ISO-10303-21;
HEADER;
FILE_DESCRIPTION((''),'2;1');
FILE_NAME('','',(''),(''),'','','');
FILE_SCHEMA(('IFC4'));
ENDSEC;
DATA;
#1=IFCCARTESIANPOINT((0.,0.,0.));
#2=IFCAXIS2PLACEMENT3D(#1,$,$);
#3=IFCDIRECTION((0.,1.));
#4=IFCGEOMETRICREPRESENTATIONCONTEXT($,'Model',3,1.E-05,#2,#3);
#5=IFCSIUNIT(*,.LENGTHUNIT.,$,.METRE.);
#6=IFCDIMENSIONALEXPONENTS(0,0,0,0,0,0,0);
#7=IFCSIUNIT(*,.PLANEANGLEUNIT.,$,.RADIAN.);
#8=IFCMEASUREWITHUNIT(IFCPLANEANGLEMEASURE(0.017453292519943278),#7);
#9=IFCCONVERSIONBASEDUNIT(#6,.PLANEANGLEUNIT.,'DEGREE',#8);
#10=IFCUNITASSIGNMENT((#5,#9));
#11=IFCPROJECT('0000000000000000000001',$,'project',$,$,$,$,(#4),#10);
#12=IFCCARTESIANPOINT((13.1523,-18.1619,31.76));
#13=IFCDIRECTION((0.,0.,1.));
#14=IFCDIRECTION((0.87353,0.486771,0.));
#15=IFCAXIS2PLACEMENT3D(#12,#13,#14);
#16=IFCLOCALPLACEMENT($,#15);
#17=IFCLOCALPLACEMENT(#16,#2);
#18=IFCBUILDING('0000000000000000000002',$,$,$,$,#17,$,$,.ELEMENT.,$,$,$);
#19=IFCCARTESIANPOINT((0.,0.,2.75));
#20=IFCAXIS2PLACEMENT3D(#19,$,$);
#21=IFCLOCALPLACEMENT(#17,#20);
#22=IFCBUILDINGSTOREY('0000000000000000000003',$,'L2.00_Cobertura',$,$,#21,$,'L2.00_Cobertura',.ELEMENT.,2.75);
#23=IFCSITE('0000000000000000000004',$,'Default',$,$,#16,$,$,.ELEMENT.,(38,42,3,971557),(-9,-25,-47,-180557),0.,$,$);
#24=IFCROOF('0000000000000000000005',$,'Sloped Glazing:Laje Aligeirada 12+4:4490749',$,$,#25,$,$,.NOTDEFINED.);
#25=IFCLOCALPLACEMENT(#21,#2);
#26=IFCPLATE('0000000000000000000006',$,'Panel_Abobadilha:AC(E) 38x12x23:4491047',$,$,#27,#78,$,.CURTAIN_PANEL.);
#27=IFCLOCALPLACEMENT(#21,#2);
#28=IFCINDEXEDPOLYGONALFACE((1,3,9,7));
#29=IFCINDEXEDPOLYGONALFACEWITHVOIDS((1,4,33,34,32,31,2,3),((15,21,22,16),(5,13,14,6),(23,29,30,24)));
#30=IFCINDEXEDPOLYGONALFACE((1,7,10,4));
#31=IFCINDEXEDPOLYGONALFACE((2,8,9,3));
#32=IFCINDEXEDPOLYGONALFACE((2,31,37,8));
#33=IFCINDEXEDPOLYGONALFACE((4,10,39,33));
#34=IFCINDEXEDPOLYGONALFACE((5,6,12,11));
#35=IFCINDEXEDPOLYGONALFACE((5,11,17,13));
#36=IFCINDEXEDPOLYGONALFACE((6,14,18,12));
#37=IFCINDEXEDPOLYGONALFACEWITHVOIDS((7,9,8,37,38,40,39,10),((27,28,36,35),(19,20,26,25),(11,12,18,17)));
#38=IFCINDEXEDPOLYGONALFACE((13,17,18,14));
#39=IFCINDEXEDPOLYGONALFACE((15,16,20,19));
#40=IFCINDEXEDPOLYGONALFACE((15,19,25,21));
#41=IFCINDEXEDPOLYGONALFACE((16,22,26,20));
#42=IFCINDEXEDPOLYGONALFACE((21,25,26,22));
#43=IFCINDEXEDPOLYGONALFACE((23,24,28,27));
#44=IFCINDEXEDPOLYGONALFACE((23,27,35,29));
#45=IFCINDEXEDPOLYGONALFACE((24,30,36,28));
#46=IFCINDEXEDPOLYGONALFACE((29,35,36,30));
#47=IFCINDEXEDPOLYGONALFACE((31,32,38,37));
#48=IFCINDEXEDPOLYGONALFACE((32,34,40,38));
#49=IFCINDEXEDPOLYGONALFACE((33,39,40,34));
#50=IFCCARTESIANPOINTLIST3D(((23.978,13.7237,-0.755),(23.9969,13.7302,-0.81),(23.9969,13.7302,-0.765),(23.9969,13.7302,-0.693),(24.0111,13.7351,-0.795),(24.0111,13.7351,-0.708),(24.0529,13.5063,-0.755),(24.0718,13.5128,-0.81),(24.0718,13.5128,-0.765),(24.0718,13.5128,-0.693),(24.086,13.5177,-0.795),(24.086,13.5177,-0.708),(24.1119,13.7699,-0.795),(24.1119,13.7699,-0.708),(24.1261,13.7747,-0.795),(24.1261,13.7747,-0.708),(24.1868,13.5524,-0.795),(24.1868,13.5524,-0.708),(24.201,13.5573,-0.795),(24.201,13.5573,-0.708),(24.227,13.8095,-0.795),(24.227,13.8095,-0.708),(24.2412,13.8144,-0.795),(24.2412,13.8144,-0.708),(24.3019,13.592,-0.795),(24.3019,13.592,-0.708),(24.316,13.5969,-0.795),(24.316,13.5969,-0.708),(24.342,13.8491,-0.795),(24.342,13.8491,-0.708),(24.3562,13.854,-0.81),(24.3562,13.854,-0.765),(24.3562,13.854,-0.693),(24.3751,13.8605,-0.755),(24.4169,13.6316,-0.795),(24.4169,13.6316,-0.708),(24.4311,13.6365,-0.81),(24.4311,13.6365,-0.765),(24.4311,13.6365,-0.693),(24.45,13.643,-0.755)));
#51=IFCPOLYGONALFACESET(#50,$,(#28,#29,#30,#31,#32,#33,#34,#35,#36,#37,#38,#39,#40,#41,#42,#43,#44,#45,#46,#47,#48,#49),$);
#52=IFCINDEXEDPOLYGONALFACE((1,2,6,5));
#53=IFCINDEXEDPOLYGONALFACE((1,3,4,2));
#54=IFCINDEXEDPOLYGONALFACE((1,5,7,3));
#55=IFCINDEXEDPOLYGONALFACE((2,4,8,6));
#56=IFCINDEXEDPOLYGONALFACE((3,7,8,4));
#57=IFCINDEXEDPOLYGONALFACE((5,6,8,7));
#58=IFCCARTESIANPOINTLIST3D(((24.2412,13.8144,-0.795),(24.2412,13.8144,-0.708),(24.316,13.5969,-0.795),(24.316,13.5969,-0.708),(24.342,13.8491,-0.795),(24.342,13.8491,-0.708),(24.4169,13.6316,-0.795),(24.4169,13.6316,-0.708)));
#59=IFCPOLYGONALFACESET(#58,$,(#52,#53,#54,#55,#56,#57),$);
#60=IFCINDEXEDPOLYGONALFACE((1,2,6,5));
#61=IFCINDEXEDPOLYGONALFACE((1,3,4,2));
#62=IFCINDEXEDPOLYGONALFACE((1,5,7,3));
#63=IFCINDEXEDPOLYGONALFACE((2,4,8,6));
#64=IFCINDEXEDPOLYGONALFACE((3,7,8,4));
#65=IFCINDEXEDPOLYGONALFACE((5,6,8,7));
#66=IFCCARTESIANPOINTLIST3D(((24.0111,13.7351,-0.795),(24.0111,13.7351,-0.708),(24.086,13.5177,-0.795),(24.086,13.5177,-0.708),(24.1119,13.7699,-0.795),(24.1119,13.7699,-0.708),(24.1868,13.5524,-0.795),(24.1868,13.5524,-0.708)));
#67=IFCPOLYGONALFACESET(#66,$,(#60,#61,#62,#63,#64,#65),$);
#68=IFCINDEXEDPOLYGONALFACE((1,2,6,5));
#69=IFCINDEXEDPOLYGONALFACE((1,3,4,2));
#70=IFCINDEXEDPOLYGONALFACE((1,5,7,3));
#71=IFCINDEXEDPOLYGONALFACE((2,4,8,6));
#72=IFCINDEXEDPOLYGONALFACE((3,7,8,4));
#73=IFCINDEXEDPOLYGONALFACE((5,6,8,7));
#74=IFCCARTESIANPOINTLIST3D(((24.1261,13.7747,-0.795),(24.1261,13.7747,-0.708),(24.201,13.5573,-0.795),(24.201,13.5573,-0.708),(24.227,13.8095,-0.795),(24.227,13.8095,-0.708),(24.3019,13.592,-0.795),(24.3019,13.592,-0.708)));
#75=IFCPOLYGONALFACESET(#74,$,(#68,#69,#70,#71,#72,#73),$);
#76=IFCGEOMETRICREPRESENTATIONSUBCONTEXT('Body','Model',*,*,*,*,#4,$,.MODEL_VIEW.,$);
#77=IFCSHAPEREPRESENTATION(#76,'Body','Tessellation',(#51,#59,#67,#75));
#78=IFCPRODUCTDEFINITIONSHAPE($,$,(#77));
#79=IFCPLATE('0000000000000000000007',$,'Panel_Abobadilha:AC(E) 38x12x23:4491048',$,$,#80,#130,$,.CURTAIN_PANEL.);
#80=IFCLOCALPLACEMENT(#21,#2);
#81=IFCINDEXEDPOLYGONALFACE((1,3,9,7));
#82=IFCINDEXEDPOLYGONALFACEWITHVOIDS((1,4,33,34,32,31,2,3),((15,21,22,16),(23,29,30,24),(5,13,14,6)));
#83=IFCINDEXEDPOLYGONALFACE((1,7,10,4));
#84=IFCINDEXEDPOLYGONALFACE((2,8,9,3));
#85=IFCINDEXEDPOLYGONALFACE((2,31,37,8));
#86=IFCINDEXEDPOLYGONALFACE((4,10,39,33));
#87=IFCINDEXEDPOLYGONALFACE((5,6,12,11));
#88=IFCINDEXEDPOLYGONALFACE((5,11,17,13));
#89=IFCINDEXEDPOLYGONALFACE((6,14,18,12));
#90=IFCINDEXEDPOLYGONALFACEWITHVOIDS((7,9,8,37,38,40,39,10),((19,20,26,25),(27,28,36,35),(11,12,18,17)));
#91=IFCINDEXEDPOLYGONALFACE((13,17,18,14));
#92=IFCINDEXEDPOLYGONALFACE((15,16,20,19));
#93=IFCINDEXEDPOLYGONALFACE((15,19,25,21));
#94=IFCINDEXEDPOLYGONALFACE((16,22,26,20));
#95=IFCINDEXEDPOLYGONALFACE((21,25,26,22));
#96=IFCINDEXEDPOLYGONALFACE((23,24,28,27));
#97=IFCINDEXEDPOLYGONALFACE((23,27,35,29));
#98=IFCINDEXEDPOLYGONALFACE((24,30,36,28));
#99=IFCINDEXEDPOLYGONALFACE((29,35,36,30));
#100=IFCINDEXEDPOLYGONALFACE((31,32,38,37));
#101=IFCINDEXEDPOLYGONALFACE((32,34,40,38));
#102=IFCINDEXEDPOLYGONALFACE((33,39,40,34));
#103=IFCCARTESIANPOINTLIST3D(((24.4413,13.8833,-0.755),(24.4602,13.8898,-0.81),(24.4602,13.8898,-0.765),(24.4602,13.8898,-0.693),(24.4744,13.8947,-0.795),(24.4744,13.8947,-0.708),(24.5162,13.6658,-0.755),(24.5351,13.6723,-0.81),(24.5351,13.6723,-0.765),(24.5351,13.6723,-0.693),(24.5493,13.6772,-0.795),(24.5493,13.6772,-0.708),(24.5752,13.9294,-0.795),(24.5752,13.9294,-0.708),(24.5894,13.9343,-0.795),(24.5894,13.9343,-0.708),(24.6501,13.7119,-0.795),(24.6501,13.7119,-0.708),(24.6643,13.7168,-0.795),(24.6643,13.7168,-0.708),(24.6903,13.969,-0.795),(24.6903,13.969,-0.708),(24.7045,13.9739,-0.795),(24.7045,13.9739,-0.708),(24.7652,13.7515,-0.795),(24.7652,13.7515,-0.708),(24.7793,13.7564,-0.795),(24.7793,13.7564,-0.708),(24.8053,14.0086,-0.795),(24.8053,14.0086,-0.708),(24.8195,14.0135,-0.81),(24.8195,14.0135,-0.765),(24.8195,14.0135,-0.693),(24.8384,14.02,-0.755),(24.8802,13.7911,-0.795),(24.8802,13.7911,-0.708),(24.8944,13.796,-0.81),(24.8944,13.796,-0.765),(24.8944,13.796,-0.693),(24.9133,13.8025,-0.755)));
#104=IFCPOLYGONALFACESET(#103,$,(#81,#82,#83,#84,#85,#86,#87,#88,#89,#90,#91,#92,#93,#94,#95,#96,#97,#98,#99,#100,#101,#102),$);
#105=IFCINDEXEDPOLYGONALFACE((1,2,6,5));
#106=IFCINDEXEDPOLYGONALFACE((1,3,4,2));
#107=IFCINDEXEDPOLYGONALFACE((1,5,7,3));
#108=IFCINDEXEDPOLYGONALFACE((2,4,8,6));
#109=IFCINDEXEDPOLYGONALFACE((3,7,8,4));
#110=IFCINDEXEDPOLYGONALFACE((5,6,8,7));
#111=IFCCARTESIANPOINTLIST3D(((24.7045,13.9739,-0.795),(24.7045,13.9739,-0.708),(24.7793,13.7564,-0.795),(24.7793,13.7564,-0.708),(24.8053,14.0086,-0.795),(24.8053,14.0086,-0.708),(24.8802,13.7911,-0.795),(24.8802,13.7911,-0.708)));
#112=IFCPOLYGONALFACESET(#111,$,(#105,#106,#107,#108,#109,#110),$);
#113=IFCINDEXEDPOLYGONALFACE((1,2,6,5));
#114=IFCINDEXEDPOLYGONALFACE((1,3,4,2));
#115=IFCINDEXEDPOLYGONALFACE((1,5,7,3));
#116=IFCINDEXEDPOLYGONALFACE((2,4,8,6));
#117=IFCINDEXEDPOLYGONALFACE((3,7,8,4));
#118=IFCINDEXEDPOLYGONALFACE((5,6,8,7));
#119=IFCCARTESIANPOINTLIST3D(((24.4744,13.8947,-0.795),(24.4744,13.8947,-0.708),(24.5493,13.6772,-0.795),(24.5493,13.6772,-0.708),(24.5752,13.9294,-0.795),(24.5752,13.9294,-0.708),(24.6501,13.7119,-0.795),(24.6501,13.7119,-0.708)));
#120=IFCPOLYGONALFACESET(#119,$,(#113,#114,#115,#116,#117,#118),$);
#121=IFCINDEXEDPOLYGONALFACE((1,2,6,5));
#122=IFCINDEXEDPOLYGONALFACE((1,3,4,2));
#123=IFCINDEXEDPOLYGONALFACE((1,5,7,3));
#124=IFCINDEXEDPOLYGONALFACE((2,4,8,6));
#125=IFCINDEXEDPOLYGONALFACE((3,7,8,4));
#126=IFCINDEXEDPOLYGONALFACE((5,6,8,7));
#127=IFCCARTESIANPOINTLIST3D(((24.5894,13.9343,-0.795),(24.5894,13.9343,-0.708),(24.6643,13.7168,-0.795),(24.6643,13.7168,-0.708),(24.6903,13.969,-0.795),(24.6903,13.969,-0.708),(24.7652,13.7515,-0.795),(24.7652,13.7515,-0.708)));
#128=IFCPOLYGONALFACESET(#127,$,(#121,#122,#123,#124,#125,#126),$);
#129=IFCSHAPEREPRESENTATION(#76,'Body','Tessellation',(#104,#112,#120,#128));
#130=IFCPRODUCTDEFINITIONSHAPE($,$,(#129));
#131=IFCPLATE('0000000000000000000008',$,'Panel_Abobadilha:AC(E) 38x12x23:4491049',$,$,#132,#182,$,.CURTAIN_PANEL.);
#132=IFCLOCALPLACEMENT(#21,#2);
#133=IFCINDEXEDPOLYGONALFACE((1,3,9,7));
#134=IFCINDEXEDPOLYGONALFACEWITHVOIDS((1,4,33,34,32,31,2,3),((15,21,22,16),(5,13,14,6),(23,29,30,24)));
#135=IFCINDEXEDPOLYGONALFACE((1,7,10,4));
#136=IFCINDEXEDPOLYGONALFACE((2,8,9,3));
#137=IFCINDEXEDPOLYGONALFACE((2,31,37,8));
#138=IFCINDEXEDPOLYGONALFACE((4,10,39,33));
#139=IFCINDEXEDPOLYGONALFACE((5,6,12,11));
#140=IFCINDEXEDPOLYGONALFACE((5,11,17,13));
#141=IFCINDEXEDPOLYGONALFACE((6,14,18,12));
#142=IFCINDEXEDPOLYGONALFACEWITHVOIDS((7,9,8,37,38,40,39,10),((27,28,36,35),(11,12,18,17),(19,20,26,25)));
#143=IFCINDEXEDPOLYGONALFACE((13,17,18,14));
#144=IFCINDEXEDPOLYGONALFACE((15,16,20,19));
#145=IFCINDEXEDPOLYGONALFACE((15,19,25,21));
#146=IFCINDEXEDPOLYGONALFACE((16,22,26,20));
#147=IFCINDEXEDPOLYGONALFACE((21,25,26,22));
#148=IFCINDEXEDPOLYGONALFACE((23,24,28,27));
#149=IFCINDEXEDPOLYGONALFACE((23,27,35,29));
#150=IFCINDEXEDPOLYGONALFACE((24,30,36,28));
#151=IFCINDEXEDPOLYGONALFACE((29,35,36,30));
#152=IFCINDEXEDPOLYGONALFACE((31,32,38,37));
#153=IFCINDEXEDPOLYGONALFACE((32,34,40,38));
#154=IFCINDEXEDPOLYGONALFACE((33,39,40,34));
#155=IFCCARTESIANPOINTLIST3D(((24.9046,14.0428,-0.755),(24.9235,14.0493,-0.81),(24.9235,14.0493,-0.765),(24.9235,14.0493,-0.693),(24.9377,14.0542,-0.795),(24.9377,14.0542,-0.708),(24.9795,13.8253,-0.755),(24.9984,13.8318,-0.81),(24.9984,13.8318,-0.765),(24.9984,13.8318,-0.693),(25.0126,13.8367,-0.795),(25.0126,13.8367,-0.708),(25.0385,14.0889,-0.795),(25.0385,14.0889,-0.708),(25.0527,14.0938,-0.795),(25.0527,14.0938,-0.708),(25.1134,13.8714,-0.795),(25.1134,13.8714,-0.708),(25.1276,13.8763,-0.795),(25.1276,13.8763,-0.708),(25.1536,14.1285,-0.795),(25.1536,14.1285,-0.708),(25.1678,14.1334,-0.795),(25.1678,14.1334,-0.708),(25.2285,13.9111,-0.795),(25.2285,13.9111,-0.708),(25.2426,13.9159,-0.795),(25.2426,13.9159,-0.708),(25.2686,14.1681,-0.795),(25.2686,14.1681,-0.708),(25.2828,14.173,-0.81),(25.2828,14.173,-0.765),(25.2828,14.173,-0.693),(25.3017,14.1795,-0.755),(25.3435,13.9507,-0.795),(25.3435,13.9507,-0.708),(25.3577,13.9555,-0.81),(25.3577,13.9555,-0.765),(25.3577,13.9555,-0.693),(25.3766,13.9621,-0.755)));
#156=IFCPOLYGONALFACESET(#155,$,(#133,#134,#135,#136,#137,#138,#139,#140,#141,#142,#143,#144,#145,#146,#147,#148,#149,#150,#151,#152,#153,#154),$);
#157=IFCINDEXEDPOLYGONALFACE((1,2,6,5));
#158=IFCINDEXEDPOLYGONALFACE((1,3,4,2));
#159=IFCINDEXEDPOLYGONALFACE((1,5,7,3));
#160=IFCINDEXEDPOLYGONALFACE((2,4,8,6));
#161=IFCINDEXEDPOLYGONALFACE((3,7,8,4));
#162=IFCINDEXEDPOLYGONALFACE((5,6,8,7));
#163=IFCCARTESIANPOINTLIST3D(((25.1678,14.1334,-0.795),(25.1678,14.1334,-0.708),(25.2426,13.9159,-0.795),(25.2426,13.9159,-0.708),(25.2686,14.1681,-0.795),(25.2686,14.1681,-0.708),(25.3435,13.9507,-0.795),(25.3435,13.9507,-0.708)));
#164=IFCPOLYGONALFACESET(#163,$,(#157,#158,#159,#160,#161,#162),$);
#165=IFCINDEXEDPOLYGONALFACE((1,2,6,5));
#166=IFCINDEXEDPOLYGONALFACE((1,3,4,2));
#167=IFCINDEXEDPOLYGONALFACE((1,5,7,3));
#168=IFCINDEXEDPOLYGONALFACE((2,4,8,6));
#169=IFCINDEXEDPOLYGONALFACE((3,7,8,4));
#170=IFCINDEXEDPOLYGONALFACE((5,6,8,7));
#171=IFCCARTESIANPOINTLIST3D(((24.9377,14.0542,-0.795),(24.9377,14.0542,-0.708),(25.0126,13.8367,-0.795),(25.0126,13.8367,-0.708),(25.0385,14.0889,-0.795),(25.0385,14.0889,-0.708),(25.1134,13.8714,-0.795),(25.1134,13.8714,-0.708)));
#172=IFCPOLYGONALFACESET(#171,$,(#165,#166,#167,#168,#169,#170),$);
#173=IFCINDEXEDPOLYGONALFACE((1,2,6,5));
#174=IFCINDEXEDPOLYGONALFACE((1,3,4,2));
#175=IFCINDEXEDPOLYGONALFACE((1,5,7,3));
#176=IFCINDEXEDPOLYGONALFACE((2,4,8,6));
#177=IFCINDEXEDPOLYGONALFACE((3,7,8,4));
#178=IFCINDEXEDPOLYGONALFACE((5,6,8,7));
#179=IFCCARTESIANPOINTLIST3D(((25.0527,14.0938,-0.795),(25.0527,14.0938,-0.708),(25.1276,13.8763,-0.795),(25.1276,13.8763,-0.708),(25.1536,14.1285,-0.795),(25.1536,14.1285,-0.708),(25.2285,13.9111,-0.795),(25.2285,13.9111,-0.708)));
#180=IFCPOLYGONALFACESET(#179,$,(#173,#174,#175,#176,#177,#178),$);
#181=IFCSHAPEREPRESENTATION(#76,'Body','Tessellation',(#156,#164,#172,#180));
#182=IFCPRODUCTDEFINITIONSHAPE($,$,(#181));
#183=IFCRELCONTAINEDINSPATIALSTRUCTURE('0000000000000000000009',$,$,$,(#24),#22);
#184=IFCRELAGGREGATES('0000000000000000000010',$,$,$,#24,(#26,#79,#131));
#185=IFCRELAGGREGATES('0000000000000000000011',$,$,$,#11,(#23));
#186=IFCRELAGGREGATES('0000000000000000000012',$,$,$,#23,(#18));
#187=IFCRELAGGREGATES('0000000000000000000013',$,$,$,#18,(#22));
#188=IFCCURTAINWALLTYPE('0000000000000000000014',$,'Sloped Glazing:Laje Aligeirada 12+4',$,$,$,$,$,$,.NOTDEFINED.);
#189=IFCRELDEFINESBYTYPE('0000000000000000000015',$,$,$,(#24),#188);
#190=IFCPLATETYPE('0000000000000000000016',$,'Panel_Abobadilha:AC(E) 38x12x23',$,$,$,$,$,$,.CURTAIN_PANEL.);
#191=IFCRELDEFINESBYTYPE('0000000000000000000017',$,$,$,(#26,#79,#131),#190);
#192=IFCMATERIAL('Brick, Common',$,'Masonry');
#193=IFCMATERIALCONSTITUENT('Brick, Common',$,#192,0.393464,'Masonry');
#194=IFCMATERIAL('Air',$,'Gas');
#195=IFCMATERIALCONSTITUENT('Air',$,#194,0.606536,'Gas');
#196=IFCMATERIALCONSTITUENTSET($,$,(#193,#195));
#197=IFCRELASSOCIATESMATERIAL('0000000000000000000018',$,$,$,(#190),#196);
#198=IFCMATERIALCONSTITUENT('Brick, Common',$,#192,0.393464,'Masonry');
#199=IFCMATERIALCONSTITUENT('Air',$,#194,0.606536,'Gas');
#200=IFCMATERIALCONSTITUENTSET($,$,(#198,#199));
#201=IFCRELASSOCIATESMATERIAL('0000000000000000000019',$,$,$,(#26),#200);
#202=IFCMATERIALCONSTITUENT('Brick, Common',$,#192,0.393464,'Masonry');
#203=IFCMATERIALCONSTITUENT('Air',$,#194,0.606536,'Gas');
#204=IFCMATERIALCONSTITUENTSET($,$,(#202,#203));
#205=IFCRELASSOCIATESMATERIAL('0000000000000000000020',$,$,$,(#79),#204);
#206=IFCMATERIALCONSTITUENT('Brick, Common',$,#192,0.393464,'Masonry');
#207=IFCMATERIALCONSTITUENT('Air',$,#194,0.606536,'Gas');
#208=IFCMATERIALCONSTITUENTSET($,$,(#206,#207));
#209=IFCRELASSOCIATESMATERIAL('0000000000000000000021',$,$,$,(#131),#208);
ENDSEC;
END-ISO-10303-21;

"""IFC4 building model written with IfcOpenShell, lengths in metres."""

from ifc_helpers import new_model, entity, si_unit, converted_unit, direction, frame, origin, place, context, subcontext, project, spatial, indexed_curve, outline, extrude, source, transform, mapped, material, constituent, constituent_set, type_object, type_shapes, element, aggregate, save


model = new_model("IFC4")

# Units and contexts
model_context = context("Model", 3, precision=1e-05, world=origin(), true_north=direction((0.0, 1.0)))
body_context = subcontext(model_context, "Body", "Model", "MODEL_VIEW")
ifc_project = project(units=[si_unit("LENGTHUNIT", "METRE"), converted_unit("PLANEANGLEUNIT", "DEGREE", entity("IfcPlaneAngleMeasure", 0.017453292519943278), si_unit("PLANEANGLEUNIT", "RADIAN"), dimensions=[0, 0, 0, 0, 0, 0, 0])], contexts=[model_context])

# Site, building, storey
site_placement = place(None, frame((13.1523, -18.1619, 31.76), z_axis=(0.0, 0.0, 1.0), x_axis=(0.87353, 0.486771, 0.0)))
site = spatial("IfcSite", under=ifc_project, at=site_placement, Name="Default", CompositionType="ELEMENT", RefLatitude=(38, 42, 3, 971557), RefLongitude=(-9, -25, -47, -180557), RefElevation=0.0)
building_placement = place(site_placement, origin())
building = spatial("IfcBuilding", under=site, at=building_placement, CompositionType="ELEMENT")
storey_placement = place(building_placement, frame((0.0, 0.0, 2.75)))
storey = spatial("IfcBuildingStorey", under=building, at=storey_placement, Name="L2.00_Cobertura", LongName="L2.00_Cobertura", CompositionType="ELEMENT", Elevation=2.75)

# Roof, plates
curtain_wall_type = type_object("IfcCurtainWallType", Name="Sloped Glazing:Laje Aligeirada 12+4", PredefinedType="NOTDEFINED")
roof_placement = place(storey_placement, frame((0.0, 0.0, -2.75)))
roof = element("IfcRoof", 1, at=roof_placement, inside=storey, type_object=curtain_wall_type, Name="Sloped Glazing:Laje Aligeirada 12+4:4490749", PredefinedType="NOTDEFINED")
ifc_material_1 = material(Name="Brick, Common", Category="Masonry")
ifc_material_2 = material(Name="Air", Category="Gas")
ifc_constituent_1 = constituent(ifc_material_1, Name="Brick, Common", Category="Masonry", fraction=0.393464)
ifc_constituent_2 = constituent(ifc_material_2, Name="Air", Category="Gas", fraction=0.606536)
ifc_constituent_set_1 = constituent_set(constituents=[ifc_constituent_1, ifc_constituent_2])
plate_type = type_object("IfcPlateType", Name="Panel_Abobadilha:AC(E) 38x12x23", PredefinedType="CURTAIN_PANEL", material=ifc_constituent_set_1)
shared_shape_1 = source(origin(), body_context, "Body", "SweptSolid", [
    extrude(outline(indexed_curve([(-0.19, -0.0543), (0.19, -0.0543), (0.19, -0.0093), (0.21, 0.0007), (0.19, 0.0628), (-0.19, 0.0628), (-0.21, 0.0007), (-0.19, -0.0093), (-0.19, -0.0543)], self_intersect=False), holes=[indexed_curve([(-0.0683, 0.0477), (-0.0683, -0.0393), (-0.175, -0.0393), (-0.175, 0.0477), (-0.0683, 0.0477)], self_intersect=False), indexed_curve([(0.0533, 0.0477), (0.0533, -0.0393), (-0.0533, -0.0393), (-0.0533, 0.0477), (0.0533, 0.0477)], self_intersect=False), indexed_curve([(0.175, 0.0477), (0.175, -0.0393), (0.0683, -0.0393), (0.0683, 0.0477), (0.175, 0.0477)], self_intersect=False)]), frame((0.0, 0.0543, 0.0)), (0.0, 0.0, 1.0), 0.23),
    extrude(outline(indexed_curve([(-0.0533, -0.0435), (0.0533, -0.0435), (0.0533, 0.0435), (-0.0533, 0.0435), (-0.0533, -0.0435)], self_intersect=False)), frame((0.1217, 0.0585, 0.0), z_axis=(0.0, 0.0, 1.0), x_axis=(-1.0, 0.0, 0.0)), (0.0, 0.0, 1.0), 0.23),
    extrude(outline(indexed_curve([(-0.0533, -0.0435), (0.0533, -0.0435), (0.0533, 0.0435), (-0.0533, 0.0435), (-0.0533, -0.0435)], self_intersect=False)), frame((-0.1217, 0.0585, 0.0), z_axis=(0.0, 0.0, 1.0), x_axis=(-1.0, 0.0, 0.0)), (0.0, 0.0, 1.0), 0.23),
    extrude(outline(indexed_curve([(-0.0533, -0.0435), (0.0533, -0.0435), (0.0533, 0.0435), (-0.0533, 0.0435), (-0.0533, -0.0435)], self_intersect=False)), frame((0.0, 0.0585, 0.0), z_axis=(0.0, 0.0, 1.0), x_axis=(-1.0, 0.0, 0.0)), (0.0, 0.0, 1.0), 0.23),
])
type_shapes(plate_type, [shared_shape_1])
ifc_constituent_3 = constituent(ifc_material_1, Name="Brick, Common", Category="Masonry", fraction=0.393464)
ifc_constituent_4 = constituent(ifc_material_2, Name="Air", Category="Gas", fraction=0.606536)
ifc_constituent_set_2 = constituent_set(constituents=[ifc_constituent_3, ifc_constituent_4])
plate_1_placement = place(roof_placement, frame((24.1765, 13.7921, 1.94), z_axis=(0.325568, -0.945519, 0.0), x_axis=(0.945519, 0.325568, 0.0)))
plate_1 = element("IfcPlate", 2, at=plate_1_placement, type_object=plate_type, material=ifc_constituent_set_2, Name="Panel_Abobadilha:AC(E) 38x12x23:4491047", PredefinedType="CURTAIN_PANEL", context=body_context, shape_type="MappedRepresentation", body=[
    mapped(shared_shape_1, transform((0.0, 0.0, 0.0), scale=1.0)),
])
ifc_constituent_5 = constituent(ifc_material_1, Name="Brick, Common", Category="Masonry", fraction=0.393464)
ifc_constituent_6 = constituent(ifc_material_2, Name="Air", Category="Gas", fraction=0.606536)
ifc_constituent_set_3 = constituent_set(constituents=[ifc_constituent_5, ifc_constituent_6])
plate_2_placement = place(roof_placement, frame((24.6398, 13.9516, 1.94), z_axis=(0.325568, -0.945519, 0.0), x_axis=(0.945519, 0.325568, 0.0)))
plate_2 = element("IfcPlate", 3, at=plate_2_placement, type_object=plate_type, material=ifc_constituent_set_3, Name="Panel_Abobadilha:AC(E) 38x12x23:4491048", PredefinedType="CURTAIN_PANEL", context=body_context, shape_type="MappedRepresentation", body=[
    mapped(shared_shape_1, transform((0.0, 0.0, 0.0), scale=1.0)),
])
ifc_constituent_7 = constituent(ifc_material_1, Name="Brick, Common", Category="Masonry", fraction=0.393464)
ifc_constituent_8 = constituent(ifc_material_2, Name="Air", Category="Gas", fraction=0.606536)
ifc_constituent_set_4 = constituent_set(constituents=[ifc_constituent_7, ifc_constituent_8])
plate_3_placement = place(roof_placement, frame((25.1032, 14.1112, 1.94), z_axis=(0.325568, -0.945519, 0.0), x_axis=(0.945519, 0.325568, 0.0)))
plate_3 = element("IfcPlate", 4, at=plate_3_placement, type_object=plate_type, material=ifc_constituent_set_4, Name="Panel_Abobadilha:AC(E) 38x12x23:4491049", PredefinedType="CURTAIN_PANEL", context=body_context, shape_type="MappedRepresentation", body=[
    mapped(shared_shape_1, transform((0.0, 0.0, 0.0), scale=1.0)),
])
aggregate(roof, [plate_1, plate_2, plate_3])

save(model, "model.ifc")
